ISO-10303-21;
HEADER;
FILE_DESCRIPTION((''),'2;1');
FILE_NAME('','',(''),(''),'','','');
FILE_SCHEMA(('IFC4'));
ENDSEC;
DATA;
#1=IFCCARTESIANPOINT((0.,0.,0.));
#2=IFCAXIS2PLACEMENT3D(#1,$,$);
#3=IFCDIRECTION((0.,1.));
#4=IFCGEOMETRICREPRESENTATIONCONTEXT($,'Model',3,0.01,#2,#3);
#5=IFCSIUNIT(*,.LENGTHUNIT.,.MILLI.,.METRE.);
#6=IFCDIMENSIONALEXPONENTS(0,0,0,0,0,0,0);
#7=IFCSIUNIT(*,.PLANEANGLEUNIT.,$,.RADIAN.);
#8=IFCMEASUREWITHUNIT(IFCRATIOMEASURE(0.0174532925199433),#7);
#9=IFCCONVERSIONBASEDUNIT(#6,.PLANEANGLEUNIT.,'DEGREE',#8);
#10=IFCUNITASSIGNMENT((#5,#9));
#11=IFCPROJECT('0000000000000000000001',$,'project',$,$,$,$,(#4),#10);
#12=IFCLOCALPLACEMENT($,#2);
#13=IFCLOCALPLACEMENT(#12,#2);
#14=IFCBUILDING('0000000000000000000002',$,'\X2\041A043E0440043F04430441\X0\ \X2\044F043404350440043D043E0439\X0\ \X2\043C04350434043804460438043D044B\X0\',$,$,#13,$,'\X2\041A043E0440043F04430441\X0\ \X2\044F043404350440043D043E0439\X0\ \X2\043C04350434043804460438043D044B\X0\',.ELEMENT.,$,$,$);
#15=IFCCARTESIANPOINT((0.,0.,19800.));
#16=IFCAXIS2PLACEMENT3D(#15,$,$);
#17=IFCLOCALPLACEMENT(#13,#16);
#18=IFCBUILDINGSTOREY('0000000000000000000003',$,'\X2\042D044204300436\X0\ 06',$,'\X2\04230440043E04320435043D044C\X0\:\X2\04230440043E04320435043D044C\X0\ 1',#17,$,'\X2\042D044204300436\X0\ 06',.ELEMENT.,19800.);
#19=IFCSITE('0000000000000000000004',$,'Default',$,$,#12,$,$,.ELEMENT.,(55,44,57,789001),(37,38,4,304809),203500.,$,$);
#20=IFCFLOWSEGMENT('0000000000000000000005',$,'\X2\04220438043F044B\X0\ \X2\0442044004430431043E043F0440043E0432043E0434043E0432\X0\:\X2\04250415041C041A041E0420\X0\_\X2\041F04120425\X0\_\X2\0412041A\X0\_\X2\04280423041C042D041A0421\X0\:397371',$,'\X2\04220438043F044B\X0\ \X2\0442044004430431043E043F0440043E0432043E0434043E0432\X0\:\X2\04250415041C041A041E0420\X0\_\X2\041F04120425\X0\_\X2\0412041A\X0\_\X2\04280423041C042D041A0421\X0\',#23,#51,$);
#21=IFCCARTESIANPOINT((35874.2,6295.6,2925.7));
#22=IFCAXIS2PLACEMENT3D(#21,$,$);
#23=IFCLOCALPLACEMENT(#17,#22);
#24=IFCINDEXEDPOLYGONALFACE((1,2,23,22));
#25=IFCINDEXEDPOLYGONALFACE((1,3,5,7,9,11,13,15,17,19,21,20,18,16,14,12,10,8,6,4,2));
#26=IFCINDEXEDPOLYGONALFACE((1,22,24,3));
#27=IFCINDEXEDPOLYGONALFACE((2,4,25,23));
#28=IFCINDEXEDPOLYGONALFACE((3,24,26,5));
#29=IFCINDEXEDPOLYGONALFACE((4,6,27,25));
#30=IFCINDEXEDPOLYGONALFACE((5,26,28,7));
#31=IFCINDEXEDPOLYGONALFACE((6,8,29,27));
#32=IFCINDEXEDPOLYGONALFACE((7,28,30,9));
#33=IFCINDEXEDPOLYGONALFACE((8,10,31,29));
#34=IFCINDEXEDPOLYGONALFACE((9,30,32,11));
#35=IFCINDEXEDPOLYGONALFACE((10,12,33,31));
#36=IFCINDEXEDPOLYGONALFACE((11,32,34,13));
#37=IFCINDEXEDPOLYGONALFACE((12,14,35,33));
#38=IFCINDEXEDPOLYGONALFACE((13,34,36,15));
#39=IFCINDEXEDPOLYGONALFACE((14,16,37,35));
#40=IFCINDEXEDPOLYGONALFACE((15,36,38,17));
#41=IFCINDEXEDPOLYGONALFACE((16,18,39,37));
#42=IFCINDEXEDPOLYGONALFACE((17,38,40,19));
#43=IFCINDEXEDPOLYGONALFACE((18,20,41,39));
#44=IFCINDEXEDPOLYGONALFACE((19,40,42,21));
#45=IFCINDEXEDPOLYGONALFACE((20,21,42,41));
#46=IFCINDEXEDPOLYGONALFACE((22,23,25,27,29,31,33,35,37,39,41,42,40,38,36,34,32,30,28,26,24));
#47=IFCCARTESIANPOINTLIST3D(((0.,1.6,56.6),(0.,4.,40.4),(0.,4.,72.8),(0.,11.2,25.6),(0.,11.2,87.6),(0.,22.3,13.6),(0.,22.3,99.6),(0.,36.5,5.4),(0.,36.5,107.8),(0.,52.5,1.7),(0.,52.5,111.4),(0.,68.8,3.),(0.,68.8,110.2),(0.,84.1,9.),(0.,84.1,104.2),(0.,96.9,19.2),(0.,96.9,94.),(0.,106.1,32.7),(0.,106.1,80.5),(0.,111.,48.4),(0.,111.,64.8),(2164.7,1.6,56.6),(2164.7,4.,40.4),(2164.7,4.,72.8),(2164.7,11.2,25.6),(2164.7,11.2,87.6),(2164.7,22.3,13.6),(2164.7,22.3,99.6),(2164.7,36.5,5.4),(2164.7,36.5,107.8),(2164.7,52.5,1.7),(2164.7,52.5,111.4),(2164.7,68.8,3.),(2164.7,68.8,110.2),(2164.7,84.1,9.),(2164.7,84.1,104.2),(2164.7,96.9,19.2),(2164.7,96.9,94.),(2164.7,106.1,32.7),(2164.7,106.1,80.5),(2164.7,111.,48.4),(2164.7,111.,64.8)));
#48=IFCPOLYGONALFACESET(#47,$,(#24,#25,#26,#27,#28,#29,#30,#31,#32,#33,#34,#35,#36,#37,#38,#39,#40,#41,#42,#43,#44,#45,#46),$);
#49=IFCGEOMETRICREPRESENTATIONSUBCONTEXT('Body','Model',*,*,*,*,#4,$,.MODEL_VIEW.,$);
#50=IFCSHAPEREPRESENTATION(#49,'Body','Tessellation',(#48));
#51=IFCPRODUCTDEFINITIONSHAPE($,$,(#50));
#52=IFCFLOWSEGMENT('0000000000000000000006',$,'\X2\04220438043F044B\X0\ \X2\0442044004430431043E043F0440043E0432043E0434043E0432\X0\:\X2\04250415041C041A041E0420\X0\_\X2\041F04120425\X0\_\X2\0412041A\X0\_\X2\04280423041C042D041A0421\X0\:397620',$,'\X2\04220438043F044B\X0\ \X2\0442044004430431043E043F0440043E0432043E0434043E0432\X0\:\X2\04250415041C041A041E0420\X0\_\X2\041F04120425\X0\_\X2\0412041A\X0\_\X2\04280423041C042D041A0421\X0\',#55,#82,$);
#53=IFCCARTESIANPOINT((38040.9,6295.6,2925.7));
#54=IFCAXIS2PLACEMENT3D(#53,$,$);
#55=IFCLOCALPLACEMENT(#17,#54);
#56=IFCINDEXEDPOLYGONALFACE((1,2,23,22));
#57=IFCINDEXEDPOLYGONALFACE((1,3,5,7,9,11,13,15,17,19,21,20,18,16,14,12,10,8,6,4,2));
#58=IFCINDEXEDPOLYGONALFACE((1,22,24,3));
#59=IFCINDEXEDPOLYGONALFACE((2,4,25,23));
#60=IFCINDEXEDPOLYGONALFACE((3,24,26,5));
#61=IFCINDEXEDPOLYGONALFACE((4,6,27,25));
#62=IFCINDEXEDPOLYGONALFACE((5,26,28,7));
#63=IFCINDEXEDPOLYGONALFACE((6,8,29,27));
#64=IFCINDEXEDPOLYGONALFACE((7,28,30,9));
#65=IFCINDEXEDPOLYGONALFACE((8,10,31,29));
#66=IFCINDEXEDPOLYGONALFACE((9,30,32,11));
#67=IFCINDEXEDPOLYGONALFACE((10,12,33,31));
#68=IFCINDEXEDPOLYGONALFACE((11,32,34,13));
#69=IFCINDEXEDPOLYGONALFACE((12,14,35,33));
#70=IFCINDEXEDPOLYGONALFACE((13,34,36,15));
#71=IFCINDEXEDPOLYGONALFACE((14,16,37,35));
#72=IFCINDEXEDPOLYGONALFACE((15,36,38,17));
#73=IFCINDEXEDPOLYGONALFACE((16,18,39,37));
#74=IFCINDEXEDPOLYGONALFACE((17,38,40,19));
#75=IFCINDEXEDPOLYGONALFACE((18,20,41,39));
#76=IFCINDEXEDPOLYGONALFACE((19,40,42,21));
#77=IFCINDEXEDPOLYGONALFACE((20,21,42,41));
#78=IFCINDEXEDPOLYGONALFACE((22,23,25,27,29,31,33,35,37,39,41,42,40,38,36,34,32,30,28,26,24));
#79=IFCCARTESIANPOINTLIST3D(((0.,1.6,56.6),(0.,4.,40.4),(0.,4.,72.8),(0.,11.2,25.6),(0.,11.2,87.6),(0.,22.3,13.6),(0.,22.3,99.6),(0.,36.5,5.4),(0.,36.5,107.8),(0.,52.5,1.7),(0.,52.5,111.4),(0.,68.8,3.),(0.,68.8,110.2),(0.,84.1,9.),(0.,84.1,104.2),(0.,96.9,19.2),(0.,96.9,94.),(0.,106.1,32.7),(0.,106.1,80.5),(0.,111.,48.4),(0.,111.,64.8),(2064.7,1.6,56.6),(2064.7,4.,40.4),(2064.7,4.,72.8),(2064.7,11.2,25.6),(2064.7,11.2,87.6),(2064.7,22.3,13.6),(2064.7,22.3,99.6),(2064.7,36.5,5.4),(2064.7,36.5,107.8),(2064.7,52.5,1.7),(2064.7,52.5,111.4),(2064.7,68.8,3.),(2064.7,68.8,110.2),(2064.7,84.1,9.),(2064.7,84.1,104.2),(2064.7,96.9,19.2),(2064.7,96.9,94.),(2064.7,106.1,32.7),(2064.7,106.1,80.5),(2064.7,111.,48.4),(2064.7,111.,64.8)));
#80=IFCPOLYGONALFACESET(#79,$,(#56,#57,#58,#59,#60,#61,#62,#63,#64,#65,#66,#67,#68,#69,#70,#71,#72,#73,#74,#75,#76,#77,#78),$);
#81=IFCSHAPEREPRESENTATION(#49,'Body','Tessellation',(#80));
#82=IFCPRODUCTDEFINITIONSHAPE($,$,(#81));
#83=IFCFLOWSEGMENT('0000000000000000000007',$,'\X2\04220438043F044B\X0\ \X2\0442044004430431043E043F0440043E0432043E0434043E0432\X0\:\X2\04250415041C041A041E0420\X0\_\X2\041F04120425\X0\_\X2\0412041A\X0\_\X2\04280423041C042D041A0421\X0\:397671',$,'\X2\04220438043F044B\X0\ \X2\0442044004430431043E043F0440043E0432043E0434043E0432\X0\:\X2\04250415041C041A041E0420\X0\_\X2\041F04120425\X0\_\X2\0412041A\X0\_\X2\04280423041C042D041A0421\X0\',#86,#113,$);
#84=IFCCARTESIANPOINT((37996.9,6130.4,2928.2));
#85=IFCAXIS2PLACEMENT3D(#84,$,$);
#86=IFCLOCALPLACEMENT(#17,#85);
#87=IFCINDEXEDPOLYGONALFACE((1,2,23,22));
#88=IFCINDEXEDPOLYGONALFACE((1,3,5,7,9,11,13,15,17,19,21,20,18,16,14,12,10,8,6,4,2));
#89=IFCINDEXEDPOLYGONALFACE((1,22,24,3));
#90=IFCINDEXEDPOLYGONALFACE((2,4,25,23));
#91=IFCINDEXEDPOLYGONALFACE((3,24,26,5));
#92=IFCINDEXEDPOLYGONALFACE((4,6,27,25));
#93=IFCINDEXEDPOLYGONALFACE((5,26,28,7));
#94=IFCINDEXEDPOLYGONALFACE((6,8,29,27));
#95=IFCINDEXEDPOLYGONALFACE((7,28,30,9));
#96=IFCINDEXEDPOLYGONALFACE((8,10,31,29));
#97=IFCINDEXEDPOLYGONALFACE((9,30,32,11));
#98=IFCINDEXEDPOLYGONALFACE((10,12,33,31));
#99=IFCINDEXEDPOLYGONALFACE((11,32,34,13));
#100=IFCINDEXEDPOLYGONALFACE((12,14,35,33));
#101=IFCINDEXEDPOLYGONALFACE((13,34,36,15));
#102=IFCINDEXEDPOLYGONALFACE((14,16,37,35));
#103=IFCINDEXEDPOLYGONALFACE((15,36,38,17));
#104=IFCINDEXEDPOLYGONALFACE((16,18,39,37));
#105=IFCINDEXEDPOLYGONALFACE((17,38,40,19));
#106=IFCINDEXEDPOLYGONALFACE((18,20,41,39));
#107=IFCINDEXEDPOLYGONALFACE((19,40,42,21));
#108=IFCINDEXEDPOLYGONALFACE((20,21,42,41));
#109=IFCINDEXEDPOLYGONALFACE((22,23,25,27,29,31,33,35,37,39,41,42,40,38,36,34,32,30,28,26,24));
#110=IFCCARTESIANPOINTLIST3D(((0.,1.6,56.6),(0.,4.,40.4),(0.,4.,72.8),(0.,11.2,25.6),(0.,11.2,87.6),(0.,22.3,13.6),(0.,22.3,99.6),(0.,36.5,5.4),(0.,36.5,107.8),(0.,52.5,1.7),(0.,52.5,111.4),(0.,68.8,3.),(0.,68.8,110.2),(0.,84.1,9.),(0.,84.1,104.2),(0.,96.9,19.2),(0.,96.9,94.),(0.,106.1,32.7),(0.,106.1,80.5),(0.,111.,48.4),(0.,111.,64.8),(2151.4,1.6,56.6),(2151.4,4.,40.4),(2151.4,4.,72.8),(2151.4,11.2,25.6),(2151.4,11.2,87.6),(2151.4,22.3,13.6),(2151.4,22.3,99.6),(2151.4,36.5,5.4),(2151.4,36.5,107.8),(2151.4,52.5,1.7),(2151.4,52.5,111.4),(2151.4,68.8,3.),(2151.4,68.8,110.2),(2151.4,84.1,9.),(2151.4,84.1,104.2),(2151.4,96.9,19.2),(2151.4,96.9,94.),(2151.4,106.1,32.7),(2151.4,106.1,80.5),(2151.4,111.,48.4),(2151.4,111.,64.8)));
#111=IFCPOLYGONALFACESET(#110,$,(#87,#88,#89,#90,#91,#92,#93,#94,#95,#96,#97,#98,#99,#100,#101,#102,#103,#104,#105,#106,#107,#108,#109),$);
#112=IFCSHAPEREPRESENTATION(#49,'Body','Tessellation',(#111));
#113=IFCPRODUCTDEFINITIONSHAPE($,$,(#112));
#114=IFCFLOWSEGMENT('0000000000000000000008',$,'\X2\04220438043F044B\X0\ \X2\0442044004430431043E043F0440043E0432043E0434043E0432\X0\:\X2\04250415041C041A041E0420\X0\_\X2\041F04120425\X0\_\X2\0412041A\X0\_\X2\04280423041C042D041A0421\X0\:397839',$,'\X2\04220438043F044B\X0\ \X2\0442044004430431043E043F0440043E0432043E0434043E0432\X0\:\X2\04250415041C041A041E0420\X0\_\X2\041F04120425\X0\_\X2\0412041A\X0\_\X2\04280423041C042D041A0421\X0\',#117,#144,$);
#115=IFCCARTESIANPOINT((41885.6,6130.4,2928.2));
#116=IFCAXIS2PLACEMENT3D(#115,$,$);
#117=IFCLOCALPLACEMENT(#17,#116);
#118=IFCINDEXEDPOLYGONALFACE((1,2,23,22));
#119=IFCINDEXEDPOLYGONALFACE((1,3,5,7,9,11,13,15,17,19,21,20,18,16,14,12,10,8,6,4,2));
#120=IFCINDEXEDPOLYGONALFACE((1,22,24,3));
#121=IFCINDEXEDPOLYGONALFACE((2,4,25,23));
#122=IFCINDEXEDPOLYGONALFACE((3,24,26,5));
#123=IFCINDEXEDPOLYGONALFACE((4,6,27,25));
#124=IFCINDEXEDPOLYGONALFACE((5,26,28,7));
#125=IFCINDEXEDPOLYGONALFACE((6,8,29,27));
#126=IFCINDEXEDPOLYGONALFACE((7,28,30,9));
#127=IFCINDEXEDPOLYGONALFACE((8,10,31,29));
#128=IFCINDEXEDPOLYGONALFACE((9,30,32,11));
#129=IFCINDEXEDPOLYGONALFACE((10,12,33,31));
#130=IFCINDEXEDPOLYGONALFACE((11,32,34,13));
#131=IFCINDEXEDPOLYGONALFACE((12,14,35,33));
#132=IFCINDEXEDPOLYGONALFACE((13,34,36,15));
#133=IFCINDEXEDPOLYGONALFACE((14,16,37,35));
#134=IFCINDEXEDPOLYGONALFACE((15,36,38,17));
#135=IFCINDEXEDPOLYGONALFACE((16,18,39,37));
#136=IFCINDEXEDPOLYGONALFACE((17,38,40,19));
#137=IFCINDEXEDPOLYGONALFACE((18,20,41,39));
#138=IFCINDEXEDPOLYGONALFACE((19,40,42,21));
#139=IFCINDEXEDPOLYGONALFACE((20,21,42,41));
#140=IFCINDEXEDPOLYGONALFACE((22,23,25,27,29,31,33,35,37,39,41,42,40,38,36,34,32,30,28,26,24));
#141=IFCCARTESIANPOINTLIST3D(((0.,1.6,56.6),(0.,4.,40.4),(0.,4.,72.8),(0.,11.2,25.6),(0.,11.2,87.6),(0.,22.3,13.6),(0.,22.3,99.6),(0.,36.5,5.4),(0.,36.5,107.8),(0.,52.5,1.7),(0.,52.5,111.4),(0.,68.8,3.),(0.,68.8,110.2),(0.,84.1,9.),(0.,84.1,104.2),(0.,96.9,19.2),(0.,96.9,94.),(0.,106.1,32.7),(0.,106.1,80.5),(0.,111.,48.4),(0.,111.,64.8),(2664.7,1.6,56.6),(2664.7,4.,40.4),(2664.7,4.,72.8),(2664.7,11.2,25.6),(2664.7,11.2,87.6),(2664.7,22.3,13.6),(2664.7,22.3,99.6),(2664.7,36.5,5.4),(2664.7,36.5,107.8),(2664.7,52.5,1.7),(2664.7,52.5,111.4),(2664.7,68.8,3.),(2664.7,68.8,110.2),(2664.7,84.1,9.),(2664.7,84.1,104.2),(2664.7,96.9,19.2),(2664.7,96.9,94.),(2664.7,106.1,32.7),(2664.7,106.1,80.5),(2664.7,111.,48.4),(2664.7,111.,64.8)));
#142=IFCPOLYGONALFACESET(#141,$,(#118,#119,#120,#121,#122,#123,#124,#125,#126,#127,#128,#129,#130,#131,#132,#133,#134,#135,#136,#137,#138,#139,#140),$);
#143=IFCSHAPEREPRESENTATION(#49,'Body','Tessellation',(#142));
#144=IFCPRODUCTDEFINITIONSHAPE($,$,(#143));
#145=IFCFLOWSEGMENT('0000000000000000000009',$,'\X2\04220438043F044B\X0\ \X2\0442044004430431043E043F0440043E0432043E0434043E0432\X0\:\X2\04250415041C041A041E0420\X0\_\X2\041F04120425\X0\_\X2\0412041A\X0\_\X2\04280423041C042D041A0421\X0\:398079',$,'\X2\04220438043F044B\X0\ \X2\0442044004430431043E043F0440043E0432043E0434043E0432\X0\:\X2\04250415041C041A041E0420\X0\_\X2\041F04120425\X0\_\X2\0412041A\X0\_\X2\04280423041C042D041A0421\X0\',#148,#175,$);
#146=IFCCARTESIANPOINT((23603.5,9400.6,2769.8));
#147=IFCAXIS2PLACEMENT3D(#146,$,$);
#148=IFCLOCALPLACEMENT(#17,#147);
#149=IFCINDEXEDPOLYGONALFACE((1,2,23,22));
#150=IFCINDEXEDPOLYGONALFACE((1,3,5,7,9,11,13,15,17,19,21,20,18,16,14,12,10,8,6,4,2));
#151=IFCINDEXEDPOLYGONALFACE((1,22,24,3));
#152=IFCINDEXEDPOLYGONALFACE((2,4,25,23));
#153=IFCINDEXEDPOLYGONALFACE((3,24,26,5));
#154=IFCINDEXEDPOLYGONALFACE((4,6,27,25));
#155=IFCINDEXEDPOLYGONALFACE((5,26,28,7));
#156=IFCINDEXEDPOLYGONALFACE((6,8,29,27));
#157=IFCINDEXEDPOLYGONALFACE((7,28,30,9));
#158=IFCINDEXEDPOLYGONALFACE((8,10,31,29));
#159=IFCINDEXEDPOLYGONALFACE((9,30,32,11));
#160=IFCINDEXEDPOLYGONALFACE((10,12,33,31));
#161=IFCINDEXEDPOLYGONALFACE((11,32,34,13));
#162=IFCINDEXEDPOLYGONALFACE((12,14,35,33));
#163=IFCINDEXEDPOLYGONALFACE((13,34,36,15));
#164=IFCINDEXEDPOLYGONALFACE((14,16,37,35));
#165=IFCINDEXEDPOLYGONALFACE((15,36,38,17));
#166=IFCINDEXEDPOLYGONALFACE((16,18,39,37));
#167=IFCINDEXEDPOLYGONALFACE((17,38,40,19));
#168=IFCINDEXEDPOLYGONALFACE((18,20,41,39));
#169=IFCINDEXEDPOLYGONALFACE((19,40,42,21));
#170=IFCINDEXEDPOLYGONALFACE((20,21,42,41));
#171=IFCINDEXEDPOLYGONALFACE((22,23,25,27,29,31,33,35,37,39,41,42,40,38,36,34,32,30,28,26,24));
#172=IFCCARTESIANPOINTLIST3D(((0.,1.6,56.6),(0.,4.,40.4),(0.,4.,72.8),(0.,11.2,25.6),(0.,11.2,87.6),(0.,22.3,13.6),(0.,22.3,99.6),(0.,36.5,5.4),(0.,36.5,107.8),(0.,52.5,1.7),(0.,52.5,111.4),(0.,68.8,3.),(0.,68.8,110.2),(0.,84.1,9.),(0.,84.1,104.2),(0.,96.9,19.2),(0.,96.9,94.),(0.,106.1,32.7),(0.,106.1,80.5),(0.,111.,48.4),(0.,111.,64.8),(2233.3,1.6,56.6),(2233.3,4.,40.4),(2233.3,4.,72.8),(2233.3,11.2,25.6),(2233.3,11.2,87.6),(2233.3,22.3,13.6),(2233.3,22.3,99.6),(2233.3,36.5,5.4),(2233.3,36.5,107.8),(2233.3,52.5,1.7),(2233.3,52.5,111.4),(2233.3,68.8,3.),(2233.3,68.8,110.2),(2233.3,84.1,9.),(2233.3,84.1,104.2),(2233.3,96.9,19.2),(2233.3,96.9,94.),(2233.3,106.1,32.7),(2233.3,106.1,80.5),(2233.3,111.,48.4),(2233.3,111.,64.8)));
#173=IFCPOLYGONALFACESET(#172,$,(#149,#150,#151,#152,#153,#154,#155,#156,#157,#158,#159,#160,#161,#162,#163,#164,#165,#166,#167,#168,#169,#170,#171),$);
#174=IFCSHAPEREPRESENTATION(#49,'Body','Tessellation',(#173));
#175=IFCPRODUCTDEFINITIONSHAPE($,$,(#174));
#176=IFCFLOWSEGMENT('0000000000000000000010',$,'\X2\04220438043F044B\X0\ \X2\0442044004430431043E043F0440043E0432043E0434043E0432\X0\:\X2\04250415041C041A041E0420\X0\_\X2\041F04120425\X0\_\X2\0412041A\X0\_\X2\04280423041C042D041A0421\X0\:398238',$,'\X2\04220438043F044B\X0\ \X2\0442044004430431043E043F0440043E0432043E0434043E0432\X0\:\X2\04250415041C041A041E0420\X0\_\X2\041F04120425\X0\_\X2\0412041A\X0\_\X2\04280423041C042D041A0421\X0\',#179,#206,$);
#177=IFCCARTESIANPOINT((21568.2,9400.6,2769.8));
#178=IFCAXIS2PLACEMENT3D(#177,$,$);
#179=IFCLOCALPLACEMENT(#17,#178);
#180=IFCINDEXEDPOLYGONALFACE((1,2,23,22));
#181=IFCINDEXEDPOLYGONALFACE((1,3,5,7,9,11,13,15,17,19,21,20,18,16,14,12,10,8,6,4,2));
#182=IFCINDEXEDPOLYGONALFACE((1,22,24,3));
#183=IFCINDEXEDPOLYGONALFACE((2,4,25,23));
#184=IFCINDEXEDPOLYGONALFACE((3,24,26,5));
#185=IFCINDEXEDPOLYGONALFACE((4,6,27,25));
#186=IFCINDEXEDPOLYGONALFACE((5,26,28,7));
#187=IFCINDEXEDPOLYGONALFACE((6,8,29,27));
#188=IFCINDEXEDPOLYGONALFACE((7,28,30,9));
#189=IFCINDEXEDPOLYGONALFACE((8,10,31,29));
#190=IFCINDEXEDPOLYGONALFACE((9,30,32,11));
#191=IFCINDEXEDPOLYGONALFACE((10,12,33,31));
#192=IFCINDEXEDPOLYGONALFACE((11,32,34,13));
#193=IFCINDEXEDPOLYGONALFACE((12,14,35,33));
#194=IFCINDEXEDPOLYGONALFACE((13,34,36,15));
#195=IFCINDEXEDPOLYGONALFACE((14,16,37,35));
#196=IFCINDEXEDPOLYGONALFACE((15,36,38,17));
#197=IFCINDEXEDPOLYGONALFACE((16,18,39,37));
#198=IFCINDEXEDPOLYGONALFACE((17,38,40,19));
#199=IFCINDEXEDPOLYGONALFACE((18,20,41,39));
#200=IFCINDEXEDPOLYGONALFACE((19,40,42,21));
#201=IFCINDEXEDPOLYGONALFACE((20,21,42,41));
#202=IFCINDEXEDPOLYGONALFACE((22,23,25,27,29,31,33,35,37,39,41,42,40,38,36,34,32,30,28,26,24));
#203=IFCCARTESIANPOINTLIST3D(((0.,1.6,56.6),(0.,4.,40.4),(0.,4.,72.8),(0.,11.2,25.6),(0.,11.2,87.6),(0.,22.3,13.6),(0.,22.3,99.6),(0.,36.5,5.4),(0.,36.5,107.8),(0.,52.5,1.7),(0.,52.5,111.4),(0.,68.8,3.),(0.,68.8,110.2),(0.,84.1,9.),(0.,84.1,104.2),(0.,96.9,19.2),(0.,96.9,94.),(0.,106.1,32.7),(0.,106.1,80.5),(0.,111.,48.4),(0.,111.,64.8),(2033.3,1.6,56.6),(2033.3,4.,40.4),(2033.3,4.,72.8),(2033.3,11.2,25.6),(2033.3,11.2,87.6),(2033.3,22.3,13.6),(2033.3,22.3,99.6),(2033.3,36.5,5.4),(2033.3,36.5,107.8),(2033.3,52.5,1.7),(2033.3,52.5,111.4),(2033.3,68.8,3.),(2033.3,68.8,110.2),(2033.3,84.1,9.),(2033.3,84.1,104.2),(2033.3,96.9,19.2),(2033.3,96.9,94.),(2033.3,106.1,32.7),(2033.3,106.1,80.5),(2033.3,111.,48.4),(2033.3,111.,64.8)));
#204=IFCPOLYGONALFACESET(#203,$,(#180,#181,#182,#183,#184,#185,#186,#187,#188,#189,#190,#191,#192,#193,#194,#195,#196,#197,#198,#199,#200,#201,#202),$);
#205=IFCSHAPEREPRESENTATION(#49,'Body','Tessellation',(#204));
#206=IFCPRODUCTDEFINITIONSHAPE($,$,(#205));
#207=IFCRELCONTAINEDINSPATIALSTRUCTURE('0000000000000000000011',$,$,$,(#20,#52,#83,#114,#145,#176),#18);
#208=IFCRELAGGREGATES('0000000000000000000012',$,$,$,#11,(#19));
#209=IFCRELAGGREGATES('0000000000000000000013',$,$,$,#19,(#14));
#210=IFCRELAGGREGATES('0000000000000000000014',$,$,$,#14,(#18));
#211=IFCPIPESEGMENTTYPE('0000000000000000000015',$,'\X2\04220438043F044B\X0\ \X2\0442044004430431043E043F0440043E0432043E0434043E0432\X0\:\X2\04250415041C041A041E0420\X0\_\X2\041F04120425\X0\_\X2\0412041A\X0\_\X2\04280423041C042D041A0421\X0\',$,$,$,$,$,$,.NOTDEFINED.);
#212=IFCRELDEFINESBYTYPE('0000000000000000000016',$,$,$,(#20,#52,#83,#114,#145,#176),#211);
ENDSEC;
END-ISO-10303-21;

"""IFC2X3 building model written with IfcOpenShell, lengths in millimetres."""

from ifc_helpers import new_model, entity, si_unit, converted_unit, direction, frame, origin, origin_2d_with_axis, place, context, subcontext, project, spatial, circle, extrude, type_object, element, save


model = new_model("IFC2X3")

# Units and contexts
model_context = context("Model", 3, precision=0.01, world=origin(), true_north=direction((0.0, 1.0)))
body_context = subcontext(model_context, "Body", "Model", "MODEL_VIEW")
ifc_project = project(units=[si_unit("LENGTHUNIT", "METRE", prefix="MILLI"), converted_unit("PLANEANGLEUNIT", "DEGREE", entity("IfcRatioMeasure", 0.0174532925199433), si_unit("PLANEANGLEUNIT", "RADIAN"), dimensions=[0, 0, 0, 0, 0, 0, 0])], contexts=[model_context])

# Site, building, storey
site_placement = place(None, frame((0.0, 0.0, 0.0)))
site = spatial("IfcSite", under=ifc_project, at=site_placement, Name="Default", CompositionType="ELEMENT", RefLatitude=(55, 44, 57, 789001), RefLongitude=(37, 38, 4, 304809), RefElevation=203500.0)
building_placement = place(site_placement, origin())
building = spatial("IfcBuilding", under=site, at=building_placement, Name="Корпус ядерной медицины", LongName="Корпус ядерной медицины", CompositionType="ELEMENT")
storey_placement = place(building_placement, frame((0.0, 0.0, 19800.0)))
storey = spatial("IfcBuildingStorey", under=building, at=storey_placement, Name="Этаж 06", ObjectType="Уровень:Уровень 1", LongName="Этаж 06", CompositionType="ELEMENT", Elevation=19800.0)

# Flow segments
pipe_segment_type = type_object("IfcPipeSegmentType", Name="Типы трубопроводов:ХЕМКОР_ПВХ_ВК_ШУМЭКС", PredefinedType="NOTDEFINED")
flow_segment_1_placement = place(storey_placement, frame((35874.2, 6295.6, 2925.7)))
element("IfcFlowSegment", 1, at=flow_segment_1_placement, inside=storey, type_object=pipe_segment_type, Name="Типы трубопроводов:ХЕМКОР_ПВХ_ВК_ШУМЭКС:397371", ObjectType="Типы трубопроводов:ХЕМКОР_ПВХ_ВК_ШУМЭКС", context=body_context, shape_type="SweptSolid", body=[
    extrude(circle(Radius=55.0, at=origin_2d_with_axis()), frame((0.0, 56.6, 56.6), z_axis=(1.0, 0.0, 0.0), x_axis=(0.0, -1.0, 0.0)), (0.0, 0.0, 1.0), 2164.7),
])
flow_segment_2_placement = place(storey_placement, frame((38040.9, 6295.6, 2925.7)))
element("IfcFlowSegment", 2, at=flow_segment_2_placement, inside=storey, type_object=pipe_segment_type, Name="Типы трубопроводов:ХЕМКОР_ПВХ_ВК_ШУМЭКС:397620", ObjectType="Типы трубопроводов:ХЕМКОР_ПВХ_ВК_ШУМЭКС", context=body_context, shape_type="SweptSolid", body=[
    extrude(circle(Radius=55.0, at=origin_2d_with_axis()), frame((0.0, 56.6, 56.6), z_axis=(1.0, 0.0, 0.0), x_axis=(0.0, -1.0, 0.0)), (0.0, 0.0, 1.0), 2064.7),
])
flow_segment_3_placement = place(storey_placement, frame((37996.9, 6130.4, 2928.2)))
element("IfcFlowSegment", 3, at=flow_segment_3_placement, inside=storey, type_object=pipe_segment_type, Name="Типы трубопроводов:ХЕМКОР_ПВХ_ВК_ШУМЭКС:397671", ObjectType="Типы трубопроводов:ХЕМКОР_ПВХ_ВК_ШУМЭКС", context=body_context, shape_type="SweptSolid", body=[
    extrude(circle(Radius=55.0, at=origin_2d_with_axis()), frame((0.0, 56.6, 56.6), z_axis=(1.0, 0.0, 0.0), x_axis=(0.0, -1.0, 0.0)), (0.0, 0.0, 1.0), 2151.4),
])
flow_segment_4_placement = place(storey_placement, frame((41885.6, 6130.4, 2928.2)))
element("IfcFlowSegment", 4, at=flow_segment_4_placement, inside=storey, type_object=pipe_segment_type, Name="Типы трубопроводов:ХЕМКОР_ПВХ_ВК_ШУМЭКС:397839", ObjectType="Типы трубопроводов:ХЕМКОР_ПВХ_ВК_ШУМЭКС", context=body_context, shape_type="SweptSolid", body=[
    extrude(circle(Radius=55.0, at=origin_2d_with_axis()), frame((0.0, 56.6, 56.6), z_axis=(1.0, 0.0, 0.0), x_axis=(0.0, -1.0, 0.0)), (0.0, 0.0, 1.0), 2664.7),
])
flow_segment_5_placement = place(storey_placement, frame((23603.5, 9400.6, 2769.8)))
element("IfcFlowSegment", 5, at=flow_segment_5_placement, inside=storey, type_object=pipe_segment_type, Name="Типы трубопроводов:ХЕМКОР_ПВХ_ВК_ШУМЭКС:398079", ObjectType="Типы трубопроводов:ХЕМКОР_ПВХ_ВК_ШУМЭКС", context=body_context, shape_type="SweptSolid", body=[
    extrude(circle(Radius=55.0, at=origin_2d_with_axis()), frame((0.0, 56.6, 56.6), z_axis=(1.0, 0.0, 0.0), x_axis=(0.0, -1.0, 0.0)), (0.0, 0.0, 1.0), 2233.3),
])
flow_segment_6_placement = place(storey_placement, frame((21568.2, 9400.6, 2769.8)))
element("IfcFlowSegment", 6, at=flow_segment_6_placement, inside=storey, type_object=pipe_segment_type, Name="Типы трубопроводов:ХЕМКОР_ПВХ_ВК_ШУМЭКС:398238", ObjectType="Типы трубопроводов:ХЕМКОР_ПВХ_ВК_ШУМЭКС", context=body_context, shape_type="SweptSolid", body=[
    extrude(circle(Radius=55.0, at=origin_2d_with_axis()), frame((0.0, 56.6, 56.6), z_axis=(1.0, 0.0, 0.0), x_axis=(0.0, -1.0, 0.0)), (0.0, 0.0, 1.0), 2033.3),
])

save(model, "model.ifc")
